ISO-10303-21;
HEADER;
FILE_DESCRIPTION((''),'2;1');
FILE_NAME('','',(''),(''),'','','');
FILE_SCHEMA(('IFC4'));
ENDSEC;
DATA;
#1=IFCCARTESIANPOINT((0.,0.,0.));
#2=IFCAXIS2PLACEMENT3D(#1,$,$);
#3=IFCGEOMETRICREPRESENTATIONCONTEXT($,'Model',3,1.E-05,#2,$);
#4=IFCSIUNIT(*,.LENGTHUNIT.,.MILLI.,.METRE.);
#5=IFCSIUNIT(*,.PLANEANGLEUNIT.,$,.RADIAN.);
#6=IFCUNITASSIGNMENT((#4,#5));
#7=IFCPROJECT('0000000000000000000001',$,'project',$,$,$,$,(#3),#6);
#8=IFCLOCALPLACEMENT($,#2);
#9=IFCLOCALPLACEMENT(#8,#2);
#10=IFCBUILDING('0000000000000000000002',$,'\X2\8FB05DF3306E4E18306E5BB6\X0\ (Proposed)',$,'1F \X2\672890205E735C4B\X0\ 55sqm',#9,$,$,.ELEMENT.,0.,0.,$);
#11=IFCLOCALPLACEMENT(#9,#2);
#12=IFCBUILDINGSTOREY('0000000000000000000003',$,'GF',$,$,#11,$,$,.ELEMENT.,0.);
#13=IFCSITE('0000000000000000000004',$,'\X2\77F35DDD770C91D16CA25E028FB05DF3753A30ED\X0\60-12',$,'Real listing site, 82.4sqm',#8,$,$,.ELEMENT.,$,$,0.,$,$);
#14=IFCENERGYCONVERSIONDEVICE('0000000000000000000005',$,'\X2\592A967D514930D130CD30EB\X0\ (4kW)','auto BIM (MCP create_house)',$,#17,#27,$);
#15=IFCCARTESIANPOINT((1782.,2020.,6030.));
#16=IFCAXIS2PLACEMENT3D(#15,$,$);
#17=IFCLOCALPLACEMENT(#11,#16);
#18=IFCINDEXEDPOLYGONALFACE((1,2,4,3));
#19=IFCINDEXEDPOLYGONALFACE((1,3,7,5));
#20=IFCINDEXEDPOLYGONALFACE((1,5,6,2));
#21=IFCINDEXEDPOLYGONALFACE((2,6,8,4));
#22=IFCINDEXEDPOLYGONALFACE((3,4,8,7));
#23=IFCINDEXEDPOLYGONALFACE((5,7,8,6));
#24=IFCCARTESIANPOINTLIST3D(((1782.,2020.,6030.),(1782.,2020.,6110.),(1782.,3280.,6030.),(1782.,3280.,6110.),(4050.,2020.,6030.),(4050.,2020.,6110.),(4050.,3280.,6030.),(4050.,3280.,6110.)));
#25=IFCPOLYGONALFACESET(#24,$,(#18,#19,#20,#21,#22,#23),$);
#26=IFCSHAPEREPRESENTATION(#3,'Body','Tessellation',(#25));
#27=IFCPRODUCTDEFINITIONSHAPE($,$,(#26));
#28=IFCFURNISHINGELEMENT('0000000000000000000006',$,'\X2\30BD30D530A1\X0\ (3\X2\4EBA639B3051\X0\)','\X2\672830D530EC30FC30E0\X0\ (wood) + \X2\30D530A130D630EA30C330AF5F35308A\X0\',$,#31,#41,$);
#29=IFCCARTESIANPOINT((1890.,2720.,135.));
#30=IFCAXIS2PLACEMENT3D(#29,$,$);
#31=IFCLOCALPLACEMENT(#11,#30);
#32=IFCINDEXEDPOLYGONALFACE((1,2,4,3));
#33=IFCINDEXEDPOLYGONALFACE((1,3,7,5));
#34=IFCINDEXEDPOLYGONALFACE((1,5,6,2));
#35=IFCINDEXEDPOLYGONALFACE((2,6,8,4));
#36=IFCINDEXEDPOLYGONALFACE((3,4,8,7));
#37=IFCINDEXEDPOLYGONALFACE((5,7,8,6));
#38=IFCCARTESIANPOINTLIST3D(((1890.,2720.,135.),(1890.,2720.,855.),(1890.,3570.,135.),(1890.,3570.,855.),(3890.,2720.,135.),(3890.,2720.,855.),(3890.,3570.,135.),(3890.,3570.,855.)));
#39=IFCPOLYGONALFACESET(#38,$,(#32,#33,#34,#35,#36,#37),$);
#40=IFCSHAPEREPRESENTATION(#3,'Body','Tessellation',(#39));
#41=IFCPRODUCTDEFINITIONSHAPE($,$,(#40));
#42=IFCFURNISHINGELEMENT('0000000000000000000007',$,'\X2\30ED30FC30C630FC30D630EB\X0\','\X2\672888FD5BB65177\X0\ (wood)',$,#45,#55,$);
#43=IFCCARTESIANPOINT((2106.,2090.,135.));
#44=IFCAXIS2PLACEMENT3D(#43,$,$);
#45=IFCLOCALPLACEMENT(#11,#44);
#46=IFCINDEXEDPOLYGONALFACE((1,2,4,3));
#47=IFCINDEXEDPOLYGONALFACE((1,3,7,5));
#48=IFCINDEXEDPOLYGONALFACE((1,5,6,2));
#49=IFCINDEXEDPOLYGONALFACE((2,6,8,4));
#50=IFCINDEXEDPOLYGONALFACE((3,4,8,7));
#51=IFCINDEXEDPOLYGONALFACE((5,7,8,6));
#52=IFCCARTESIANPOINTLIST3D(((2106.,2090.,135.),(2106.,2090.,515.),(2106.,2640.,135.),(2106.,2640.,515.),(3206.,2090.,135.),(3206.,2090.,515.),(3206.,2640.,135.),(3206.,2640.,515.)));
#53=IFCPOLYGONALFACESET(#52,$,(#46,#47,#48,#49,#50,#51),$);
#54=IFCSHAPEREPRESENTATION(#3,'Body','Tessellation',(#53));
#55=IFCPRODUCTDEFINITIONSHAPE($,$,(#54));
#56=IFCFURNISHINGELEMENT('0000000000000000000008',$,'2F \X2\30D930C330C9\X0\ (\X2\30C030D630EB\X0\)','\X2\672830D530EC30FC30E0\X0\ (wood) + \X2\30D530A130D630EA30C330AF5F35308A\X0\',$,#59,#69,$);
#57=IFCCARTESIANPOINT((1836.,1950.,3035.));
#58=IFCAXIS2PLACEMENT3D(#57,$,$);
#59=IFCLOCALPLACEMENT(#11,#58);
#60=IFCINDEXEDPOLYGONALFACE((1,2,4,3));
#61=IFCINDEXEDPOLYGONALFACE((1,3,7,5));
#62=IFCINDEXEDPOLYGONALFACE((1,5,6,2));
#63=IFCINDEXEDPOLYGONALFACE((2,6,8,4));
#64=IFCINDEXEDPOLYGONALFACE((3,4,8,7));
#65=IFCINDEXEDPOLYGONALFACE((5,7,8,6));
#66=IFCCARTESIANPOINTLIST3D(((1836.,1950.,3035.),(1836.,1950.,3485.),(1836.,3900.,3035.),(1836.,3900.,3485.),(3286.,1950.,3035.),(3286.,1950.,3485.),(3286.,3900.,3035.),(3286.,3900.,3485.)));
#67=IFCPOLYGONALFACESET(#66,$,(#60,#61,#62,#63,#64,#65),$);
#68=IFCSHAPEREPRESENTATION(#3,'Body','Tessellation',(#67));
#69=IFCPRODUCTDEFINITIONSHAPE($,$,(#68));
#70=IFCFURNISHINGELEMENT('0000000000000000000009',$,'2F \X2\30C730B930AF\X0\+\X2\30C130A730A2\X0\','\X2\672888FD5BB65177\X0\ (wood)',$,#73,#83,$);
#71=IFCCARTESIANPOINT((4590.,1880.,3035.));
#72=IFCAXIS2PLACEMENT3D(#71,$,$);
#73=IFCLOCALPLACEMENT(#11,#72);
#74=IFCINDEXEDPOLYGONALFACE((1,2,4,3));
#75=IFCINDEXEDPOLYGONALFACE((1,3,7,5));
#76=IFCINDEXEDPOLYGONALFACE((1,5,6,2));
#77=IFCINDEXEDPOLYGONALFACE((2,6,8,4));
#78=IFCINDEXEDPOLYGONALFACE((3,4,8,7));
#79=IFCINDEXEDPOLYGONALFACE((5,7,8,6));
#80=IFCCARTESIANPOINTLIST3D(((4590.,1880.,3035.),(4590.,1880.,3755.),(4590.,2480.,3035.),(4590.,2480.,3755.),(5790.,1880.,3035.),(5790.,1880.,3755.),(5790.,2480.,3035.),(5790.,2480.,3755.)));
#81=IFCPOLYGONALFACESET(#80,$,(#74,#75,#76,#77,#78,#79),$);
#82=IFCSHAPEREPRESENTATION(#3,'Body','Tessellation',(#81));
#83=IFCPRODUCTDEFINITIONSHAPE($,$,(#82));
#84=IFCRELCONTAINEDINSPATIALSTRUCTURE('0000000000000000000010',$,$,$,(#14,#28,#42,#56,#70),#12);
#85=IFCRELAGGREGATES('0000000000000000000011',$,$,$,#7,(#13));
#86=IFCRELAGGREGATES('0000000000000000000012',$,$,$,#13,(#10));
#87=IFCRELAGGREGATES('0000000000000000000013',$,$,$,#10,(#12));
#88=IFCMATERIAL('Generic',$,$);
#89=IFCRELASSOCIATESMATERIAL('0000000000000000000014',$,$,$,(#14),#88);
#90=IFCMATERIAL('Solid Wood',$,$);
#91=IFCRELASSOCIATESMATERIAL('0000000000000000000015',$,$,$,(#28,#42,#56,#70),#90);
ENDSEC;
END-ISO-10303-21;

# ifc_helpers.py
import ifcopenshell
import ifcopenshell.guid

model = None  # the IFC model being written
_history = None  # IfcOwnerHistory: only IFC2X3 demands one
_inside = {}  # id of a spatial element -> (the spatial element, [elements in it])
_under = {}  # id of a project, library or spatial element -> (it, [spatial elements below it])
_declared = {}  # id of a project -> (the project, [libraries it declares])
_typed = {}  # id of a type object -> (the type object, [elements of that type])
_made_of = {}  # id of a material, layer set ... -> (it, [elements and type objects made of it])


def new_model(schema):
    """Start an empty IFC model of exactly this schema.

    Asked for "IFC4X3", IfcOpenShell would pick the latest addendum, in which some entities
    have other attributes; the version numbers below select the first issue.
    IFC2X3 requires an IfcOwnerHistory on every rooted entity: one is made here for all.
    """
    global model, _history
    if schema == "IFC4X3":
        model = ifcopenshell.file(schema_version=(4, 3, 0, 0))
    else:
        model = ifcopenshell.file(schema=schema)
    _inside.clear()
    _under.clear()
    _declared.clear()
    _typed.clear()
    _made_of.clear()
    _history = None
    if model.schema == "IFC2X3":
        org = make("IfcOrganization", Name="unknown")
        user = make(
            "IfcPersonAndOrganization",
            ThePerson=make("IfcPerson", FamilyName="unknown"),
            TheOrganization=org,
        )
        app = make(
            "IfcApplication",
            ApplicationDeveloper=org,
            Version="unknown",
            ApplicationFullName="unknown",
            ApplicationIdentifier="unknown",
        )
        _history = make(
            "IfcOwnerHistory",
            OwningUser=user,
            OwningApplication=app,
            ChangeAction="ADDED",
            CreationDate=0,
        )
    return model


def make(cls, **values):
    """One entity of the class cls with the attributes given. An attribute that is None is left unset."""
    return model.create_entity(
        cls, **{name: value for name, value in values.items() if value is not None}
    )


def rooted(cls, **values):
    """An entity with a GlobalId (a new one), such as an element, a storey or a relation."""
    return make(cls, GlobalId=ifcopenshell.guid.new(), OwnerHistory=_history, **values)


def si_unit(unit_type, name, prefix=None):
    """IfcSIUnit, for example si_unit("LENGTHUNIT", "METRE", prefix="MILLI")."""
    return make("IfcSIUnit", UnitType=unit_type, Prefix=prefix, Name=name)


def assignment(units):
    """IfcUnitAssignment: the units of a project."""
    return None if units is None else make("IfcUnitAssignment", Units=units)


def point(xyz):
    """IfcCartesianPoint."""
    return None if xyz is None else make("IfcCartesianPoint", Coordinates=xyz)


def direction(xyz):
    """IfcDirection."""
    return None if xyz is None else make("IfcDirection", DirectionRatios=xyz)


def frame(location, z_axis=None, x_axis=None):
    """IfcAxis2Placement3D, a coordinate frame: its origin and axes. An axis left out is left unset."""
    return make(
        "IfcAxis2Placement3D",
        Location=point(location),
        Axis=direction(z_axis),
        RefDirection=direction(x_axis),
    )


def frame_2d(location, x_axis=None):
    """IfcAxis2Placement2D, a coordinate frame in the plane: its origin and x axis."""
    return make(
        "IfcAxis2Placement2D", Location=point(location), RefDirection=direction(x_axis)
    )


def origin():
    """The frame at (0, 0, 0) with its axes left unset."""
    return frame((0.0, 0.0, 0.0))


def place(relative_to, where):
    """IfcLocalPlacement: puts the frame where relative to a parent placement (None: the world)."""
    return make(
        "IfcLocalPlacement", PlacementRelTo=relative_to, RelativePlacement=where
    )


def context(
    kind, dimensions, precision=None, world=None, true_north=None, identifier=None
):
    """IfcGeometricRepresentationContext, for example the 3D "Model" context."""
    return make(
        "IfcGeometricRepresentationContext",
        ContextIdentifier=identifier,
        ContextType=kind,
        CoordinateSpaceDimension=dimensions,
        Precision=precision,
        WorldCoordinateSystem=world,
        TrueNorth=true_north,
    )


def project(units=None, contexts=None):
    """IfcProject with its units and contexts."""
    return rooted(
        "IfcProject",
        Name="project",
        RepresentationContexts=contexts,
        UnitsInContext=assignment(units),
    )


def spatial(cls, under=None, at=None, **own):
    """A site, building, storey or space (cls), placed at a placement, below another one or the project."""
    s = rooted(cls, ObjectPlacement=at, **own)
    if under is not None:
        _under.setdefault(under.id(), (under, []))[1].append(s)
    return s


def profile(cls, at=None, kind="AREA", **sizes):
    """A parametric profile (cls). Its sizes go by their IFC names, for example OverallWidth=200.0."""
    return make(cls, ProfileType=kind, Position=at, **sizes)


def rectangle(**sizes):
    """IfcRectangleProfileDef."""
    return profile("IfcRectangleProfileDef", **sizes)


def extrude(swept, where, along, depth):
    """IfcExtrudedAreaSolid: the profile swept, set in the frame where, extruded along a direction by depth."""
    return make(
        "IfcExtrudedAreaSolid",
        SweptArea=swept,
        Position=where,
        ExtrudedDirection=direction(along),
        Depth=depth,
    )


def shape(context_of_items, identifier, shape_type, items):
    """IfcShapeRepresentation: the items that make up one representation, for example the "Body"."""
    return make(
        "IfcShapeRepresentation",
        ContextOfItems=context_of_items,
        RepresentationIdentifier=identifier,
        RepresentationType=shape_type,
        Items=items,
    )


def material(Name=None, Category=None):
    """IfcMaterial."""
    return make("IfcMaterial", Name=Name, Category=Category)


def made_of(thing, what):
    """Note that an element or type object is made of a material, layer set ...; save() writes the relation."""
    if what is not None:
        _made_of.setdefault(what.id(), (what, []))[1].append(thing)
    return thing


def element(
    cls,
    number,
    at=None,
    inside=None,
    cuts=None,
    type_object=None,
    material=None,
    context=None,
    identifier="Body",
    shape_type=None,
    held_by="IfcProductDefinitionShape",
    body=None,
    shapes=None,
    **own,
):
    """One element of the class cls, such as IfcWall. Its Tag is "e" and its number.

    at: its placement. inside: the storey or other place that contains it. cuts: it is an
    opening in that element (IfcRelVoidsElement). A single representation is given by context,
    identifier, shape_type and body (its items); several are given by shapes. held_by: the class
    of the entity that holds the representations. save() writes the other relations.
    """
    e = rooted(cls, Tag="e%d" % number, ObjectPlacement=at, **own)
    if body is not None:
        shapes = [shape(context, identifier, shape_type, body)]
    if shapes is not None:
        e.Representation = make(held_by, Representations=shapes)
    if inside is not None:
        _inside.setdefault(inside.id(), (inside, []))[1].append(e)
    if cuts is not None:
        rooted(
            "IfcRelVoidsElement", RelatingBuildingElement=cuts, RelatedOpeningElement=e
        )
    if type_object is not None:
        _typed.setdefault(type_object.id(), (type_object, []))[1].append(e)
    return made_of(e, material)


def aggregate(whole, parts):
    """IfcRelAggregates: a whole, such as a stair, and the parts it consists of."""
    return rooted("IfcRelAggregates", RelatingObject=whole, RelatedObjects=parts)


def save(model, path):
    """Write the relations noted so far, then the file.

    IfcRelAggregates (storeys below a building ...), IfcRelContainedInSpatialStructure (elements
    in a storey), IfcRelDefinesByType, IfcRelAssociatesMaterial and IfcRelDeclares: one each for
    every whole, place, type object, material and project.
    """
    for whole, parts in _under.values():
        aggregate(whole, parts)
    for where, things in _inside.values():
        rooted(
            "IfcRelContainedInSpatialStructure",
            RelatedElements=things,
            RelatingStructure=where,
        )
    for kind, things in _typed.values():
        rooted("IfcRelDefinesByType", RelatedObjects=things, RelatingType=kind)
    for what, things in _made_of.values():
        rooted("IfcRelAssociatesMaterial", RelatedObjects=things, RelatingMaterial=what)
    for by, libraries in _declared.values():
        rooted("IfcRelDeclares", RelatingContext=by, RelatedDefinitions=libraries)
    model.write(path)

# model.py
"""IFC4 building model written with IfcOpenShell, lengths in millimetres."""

from ifc_helpers import new_model, si_unit, frame, frame_2d, origin, place, context, project, spatial, rectangle, extrude, material, element, save


model = new_model("IFC4")

# Units and contexts
model_context = context("Model", 3, precision=1e-05, world=origin())
ifc_project = project(units=[si_unit("LENGTHUNIT", "METRE", prefix="MILLI"), si_unit("PLANEANGLEUNIT", "RADIAN")], contexts=[model_context])

# Site, building, storey
site_placement = place(None, origin())
site = spatial("IfcSite", under=ifc_project, at=site_placement, Name="石川県金沢市辰巳町ロ60-12", ObjectType="Real listing site, 82.4sqm", CompositionType="ELEMENT", RefElevation=0.0)
building_placement = place(site_placement, origin())
building = spatial("IfcBuilding", under=site, at=building_placement, Name="辰巳の丘の家 (Proposed)", ObjectType="1F 木造平屋 55sqm", CompositionType="ELEMENT", ElevationOfRefHeight=0.0, ElevationOfTerrain=0.0)
storey_placement = place(building_placement, origin())
storey = spatial("IfcBuildingStorey", under=building, at=storey_placement, Name="GF", CompositionType="ELEMENT", Elevation=0.0)

# Shared definitions
ifc_material_1 = material(Name="Solid Wood")

# Shared definitions
ifc_material_2 = material(Name="Generic")

# Energy conversion device
energy_conversion_device_placement = place(storey_placement, frame((1782.0, 2020.0, 6030.0)))
element("IfcEnergyConversionDevice", 1, at=energy_conversion_device_placement, inside=storey, material=ifc_material_2, Name="太陽光パネル (4kW)", Description="auto BIM (MCP create_house)", context=model_context, shape_type="SweptSolid", body=[
    extrude(rectangle(XDim=2268.0, YDim=1260.0, at=frame_2d((1134.0, 630.0))), frame((1782.0, 2020.0, 6030.0)), (0.0, 0.0, 1.0), 80.0),
])

# Furnishing elements
furnishing_1_placement = place(storey_placement, frame((1890.0, 2720.0, 135.0)))
element("IfcFurnishingElement", 2, at=furnishing_1_placement, inside=storey, material=ifc_material_1, Name="ソファ (3人掛け)", Description="木フレーム (wood) + ファブリック張り", context=model_context, shape_type="SweptSolid", body=[
    extrude(rectangle(XDim=2000.0, YDim=850.0, at=frame_2d((1000.0, 425.0))), frame((1890.0, 2720.0, 135.0)), (0.0, 0.0, 1.0), 720.0),
])
furnishing_2_placement = place(storey_placement, frame((2106.0, 2090.0, 135.0)))
element("IfcFurnishingElement", 3, at=furnishing_2_placement, inside=storey, material=ifc_material_1, Name="ローテーブル", Description="木製家具 (wood)", context=model_context, shape_type="SweptSolid", body=[
    extrude(rectangle(XDim=1100.0, YDim=550.0, at=frame_2d((550.0, 275.0))), frame((2106.0, 2090.0, 135.0)), (0.0, 0.0, 1.0), 380.0),
])
furnishing_3_placement = place(storey_placement, frame((1836.0, 1950.0, 3035.0)))
element("IfcFurnishingElement", 4, at=furnishing_3_placement, inside=storey, material=ifc_material_1, Name="2F ベッド (ダブル)", Description="木フレーム (wood) + ファブリック張り", context=model_context, shape_type="SweptSolid", body=[
    extrude(rectangle(XDim=1450.0, YDim=1950.0, at=frame_2d((725.0, 975.0))), frame((1836.0, 1950.0, 3035.0)), (0.0, 0.0, 1.0), 450.0),
])
furnishing_4_placement = place(storey_placement, frame((4590.0, 1880.0, 3035.0)))
element("IfcFurnishingElement", 5, at=furnishing_4_placement, inside=storey, material=ifc_material_1, Name="2F デスク+チェア", Description="木製家具 (wood)", context=model_context, shape_type="SweptSolid", body=[
    extrude(rectangle(XDim=1200.0, YDim=600.0, at=frame_2d((600.0, 300.0))), frame((4590.0, 1880.0, 3035.0)), (0.0, 0.0, 1.0), 720.0),
])

save(model, "model.ifc")
